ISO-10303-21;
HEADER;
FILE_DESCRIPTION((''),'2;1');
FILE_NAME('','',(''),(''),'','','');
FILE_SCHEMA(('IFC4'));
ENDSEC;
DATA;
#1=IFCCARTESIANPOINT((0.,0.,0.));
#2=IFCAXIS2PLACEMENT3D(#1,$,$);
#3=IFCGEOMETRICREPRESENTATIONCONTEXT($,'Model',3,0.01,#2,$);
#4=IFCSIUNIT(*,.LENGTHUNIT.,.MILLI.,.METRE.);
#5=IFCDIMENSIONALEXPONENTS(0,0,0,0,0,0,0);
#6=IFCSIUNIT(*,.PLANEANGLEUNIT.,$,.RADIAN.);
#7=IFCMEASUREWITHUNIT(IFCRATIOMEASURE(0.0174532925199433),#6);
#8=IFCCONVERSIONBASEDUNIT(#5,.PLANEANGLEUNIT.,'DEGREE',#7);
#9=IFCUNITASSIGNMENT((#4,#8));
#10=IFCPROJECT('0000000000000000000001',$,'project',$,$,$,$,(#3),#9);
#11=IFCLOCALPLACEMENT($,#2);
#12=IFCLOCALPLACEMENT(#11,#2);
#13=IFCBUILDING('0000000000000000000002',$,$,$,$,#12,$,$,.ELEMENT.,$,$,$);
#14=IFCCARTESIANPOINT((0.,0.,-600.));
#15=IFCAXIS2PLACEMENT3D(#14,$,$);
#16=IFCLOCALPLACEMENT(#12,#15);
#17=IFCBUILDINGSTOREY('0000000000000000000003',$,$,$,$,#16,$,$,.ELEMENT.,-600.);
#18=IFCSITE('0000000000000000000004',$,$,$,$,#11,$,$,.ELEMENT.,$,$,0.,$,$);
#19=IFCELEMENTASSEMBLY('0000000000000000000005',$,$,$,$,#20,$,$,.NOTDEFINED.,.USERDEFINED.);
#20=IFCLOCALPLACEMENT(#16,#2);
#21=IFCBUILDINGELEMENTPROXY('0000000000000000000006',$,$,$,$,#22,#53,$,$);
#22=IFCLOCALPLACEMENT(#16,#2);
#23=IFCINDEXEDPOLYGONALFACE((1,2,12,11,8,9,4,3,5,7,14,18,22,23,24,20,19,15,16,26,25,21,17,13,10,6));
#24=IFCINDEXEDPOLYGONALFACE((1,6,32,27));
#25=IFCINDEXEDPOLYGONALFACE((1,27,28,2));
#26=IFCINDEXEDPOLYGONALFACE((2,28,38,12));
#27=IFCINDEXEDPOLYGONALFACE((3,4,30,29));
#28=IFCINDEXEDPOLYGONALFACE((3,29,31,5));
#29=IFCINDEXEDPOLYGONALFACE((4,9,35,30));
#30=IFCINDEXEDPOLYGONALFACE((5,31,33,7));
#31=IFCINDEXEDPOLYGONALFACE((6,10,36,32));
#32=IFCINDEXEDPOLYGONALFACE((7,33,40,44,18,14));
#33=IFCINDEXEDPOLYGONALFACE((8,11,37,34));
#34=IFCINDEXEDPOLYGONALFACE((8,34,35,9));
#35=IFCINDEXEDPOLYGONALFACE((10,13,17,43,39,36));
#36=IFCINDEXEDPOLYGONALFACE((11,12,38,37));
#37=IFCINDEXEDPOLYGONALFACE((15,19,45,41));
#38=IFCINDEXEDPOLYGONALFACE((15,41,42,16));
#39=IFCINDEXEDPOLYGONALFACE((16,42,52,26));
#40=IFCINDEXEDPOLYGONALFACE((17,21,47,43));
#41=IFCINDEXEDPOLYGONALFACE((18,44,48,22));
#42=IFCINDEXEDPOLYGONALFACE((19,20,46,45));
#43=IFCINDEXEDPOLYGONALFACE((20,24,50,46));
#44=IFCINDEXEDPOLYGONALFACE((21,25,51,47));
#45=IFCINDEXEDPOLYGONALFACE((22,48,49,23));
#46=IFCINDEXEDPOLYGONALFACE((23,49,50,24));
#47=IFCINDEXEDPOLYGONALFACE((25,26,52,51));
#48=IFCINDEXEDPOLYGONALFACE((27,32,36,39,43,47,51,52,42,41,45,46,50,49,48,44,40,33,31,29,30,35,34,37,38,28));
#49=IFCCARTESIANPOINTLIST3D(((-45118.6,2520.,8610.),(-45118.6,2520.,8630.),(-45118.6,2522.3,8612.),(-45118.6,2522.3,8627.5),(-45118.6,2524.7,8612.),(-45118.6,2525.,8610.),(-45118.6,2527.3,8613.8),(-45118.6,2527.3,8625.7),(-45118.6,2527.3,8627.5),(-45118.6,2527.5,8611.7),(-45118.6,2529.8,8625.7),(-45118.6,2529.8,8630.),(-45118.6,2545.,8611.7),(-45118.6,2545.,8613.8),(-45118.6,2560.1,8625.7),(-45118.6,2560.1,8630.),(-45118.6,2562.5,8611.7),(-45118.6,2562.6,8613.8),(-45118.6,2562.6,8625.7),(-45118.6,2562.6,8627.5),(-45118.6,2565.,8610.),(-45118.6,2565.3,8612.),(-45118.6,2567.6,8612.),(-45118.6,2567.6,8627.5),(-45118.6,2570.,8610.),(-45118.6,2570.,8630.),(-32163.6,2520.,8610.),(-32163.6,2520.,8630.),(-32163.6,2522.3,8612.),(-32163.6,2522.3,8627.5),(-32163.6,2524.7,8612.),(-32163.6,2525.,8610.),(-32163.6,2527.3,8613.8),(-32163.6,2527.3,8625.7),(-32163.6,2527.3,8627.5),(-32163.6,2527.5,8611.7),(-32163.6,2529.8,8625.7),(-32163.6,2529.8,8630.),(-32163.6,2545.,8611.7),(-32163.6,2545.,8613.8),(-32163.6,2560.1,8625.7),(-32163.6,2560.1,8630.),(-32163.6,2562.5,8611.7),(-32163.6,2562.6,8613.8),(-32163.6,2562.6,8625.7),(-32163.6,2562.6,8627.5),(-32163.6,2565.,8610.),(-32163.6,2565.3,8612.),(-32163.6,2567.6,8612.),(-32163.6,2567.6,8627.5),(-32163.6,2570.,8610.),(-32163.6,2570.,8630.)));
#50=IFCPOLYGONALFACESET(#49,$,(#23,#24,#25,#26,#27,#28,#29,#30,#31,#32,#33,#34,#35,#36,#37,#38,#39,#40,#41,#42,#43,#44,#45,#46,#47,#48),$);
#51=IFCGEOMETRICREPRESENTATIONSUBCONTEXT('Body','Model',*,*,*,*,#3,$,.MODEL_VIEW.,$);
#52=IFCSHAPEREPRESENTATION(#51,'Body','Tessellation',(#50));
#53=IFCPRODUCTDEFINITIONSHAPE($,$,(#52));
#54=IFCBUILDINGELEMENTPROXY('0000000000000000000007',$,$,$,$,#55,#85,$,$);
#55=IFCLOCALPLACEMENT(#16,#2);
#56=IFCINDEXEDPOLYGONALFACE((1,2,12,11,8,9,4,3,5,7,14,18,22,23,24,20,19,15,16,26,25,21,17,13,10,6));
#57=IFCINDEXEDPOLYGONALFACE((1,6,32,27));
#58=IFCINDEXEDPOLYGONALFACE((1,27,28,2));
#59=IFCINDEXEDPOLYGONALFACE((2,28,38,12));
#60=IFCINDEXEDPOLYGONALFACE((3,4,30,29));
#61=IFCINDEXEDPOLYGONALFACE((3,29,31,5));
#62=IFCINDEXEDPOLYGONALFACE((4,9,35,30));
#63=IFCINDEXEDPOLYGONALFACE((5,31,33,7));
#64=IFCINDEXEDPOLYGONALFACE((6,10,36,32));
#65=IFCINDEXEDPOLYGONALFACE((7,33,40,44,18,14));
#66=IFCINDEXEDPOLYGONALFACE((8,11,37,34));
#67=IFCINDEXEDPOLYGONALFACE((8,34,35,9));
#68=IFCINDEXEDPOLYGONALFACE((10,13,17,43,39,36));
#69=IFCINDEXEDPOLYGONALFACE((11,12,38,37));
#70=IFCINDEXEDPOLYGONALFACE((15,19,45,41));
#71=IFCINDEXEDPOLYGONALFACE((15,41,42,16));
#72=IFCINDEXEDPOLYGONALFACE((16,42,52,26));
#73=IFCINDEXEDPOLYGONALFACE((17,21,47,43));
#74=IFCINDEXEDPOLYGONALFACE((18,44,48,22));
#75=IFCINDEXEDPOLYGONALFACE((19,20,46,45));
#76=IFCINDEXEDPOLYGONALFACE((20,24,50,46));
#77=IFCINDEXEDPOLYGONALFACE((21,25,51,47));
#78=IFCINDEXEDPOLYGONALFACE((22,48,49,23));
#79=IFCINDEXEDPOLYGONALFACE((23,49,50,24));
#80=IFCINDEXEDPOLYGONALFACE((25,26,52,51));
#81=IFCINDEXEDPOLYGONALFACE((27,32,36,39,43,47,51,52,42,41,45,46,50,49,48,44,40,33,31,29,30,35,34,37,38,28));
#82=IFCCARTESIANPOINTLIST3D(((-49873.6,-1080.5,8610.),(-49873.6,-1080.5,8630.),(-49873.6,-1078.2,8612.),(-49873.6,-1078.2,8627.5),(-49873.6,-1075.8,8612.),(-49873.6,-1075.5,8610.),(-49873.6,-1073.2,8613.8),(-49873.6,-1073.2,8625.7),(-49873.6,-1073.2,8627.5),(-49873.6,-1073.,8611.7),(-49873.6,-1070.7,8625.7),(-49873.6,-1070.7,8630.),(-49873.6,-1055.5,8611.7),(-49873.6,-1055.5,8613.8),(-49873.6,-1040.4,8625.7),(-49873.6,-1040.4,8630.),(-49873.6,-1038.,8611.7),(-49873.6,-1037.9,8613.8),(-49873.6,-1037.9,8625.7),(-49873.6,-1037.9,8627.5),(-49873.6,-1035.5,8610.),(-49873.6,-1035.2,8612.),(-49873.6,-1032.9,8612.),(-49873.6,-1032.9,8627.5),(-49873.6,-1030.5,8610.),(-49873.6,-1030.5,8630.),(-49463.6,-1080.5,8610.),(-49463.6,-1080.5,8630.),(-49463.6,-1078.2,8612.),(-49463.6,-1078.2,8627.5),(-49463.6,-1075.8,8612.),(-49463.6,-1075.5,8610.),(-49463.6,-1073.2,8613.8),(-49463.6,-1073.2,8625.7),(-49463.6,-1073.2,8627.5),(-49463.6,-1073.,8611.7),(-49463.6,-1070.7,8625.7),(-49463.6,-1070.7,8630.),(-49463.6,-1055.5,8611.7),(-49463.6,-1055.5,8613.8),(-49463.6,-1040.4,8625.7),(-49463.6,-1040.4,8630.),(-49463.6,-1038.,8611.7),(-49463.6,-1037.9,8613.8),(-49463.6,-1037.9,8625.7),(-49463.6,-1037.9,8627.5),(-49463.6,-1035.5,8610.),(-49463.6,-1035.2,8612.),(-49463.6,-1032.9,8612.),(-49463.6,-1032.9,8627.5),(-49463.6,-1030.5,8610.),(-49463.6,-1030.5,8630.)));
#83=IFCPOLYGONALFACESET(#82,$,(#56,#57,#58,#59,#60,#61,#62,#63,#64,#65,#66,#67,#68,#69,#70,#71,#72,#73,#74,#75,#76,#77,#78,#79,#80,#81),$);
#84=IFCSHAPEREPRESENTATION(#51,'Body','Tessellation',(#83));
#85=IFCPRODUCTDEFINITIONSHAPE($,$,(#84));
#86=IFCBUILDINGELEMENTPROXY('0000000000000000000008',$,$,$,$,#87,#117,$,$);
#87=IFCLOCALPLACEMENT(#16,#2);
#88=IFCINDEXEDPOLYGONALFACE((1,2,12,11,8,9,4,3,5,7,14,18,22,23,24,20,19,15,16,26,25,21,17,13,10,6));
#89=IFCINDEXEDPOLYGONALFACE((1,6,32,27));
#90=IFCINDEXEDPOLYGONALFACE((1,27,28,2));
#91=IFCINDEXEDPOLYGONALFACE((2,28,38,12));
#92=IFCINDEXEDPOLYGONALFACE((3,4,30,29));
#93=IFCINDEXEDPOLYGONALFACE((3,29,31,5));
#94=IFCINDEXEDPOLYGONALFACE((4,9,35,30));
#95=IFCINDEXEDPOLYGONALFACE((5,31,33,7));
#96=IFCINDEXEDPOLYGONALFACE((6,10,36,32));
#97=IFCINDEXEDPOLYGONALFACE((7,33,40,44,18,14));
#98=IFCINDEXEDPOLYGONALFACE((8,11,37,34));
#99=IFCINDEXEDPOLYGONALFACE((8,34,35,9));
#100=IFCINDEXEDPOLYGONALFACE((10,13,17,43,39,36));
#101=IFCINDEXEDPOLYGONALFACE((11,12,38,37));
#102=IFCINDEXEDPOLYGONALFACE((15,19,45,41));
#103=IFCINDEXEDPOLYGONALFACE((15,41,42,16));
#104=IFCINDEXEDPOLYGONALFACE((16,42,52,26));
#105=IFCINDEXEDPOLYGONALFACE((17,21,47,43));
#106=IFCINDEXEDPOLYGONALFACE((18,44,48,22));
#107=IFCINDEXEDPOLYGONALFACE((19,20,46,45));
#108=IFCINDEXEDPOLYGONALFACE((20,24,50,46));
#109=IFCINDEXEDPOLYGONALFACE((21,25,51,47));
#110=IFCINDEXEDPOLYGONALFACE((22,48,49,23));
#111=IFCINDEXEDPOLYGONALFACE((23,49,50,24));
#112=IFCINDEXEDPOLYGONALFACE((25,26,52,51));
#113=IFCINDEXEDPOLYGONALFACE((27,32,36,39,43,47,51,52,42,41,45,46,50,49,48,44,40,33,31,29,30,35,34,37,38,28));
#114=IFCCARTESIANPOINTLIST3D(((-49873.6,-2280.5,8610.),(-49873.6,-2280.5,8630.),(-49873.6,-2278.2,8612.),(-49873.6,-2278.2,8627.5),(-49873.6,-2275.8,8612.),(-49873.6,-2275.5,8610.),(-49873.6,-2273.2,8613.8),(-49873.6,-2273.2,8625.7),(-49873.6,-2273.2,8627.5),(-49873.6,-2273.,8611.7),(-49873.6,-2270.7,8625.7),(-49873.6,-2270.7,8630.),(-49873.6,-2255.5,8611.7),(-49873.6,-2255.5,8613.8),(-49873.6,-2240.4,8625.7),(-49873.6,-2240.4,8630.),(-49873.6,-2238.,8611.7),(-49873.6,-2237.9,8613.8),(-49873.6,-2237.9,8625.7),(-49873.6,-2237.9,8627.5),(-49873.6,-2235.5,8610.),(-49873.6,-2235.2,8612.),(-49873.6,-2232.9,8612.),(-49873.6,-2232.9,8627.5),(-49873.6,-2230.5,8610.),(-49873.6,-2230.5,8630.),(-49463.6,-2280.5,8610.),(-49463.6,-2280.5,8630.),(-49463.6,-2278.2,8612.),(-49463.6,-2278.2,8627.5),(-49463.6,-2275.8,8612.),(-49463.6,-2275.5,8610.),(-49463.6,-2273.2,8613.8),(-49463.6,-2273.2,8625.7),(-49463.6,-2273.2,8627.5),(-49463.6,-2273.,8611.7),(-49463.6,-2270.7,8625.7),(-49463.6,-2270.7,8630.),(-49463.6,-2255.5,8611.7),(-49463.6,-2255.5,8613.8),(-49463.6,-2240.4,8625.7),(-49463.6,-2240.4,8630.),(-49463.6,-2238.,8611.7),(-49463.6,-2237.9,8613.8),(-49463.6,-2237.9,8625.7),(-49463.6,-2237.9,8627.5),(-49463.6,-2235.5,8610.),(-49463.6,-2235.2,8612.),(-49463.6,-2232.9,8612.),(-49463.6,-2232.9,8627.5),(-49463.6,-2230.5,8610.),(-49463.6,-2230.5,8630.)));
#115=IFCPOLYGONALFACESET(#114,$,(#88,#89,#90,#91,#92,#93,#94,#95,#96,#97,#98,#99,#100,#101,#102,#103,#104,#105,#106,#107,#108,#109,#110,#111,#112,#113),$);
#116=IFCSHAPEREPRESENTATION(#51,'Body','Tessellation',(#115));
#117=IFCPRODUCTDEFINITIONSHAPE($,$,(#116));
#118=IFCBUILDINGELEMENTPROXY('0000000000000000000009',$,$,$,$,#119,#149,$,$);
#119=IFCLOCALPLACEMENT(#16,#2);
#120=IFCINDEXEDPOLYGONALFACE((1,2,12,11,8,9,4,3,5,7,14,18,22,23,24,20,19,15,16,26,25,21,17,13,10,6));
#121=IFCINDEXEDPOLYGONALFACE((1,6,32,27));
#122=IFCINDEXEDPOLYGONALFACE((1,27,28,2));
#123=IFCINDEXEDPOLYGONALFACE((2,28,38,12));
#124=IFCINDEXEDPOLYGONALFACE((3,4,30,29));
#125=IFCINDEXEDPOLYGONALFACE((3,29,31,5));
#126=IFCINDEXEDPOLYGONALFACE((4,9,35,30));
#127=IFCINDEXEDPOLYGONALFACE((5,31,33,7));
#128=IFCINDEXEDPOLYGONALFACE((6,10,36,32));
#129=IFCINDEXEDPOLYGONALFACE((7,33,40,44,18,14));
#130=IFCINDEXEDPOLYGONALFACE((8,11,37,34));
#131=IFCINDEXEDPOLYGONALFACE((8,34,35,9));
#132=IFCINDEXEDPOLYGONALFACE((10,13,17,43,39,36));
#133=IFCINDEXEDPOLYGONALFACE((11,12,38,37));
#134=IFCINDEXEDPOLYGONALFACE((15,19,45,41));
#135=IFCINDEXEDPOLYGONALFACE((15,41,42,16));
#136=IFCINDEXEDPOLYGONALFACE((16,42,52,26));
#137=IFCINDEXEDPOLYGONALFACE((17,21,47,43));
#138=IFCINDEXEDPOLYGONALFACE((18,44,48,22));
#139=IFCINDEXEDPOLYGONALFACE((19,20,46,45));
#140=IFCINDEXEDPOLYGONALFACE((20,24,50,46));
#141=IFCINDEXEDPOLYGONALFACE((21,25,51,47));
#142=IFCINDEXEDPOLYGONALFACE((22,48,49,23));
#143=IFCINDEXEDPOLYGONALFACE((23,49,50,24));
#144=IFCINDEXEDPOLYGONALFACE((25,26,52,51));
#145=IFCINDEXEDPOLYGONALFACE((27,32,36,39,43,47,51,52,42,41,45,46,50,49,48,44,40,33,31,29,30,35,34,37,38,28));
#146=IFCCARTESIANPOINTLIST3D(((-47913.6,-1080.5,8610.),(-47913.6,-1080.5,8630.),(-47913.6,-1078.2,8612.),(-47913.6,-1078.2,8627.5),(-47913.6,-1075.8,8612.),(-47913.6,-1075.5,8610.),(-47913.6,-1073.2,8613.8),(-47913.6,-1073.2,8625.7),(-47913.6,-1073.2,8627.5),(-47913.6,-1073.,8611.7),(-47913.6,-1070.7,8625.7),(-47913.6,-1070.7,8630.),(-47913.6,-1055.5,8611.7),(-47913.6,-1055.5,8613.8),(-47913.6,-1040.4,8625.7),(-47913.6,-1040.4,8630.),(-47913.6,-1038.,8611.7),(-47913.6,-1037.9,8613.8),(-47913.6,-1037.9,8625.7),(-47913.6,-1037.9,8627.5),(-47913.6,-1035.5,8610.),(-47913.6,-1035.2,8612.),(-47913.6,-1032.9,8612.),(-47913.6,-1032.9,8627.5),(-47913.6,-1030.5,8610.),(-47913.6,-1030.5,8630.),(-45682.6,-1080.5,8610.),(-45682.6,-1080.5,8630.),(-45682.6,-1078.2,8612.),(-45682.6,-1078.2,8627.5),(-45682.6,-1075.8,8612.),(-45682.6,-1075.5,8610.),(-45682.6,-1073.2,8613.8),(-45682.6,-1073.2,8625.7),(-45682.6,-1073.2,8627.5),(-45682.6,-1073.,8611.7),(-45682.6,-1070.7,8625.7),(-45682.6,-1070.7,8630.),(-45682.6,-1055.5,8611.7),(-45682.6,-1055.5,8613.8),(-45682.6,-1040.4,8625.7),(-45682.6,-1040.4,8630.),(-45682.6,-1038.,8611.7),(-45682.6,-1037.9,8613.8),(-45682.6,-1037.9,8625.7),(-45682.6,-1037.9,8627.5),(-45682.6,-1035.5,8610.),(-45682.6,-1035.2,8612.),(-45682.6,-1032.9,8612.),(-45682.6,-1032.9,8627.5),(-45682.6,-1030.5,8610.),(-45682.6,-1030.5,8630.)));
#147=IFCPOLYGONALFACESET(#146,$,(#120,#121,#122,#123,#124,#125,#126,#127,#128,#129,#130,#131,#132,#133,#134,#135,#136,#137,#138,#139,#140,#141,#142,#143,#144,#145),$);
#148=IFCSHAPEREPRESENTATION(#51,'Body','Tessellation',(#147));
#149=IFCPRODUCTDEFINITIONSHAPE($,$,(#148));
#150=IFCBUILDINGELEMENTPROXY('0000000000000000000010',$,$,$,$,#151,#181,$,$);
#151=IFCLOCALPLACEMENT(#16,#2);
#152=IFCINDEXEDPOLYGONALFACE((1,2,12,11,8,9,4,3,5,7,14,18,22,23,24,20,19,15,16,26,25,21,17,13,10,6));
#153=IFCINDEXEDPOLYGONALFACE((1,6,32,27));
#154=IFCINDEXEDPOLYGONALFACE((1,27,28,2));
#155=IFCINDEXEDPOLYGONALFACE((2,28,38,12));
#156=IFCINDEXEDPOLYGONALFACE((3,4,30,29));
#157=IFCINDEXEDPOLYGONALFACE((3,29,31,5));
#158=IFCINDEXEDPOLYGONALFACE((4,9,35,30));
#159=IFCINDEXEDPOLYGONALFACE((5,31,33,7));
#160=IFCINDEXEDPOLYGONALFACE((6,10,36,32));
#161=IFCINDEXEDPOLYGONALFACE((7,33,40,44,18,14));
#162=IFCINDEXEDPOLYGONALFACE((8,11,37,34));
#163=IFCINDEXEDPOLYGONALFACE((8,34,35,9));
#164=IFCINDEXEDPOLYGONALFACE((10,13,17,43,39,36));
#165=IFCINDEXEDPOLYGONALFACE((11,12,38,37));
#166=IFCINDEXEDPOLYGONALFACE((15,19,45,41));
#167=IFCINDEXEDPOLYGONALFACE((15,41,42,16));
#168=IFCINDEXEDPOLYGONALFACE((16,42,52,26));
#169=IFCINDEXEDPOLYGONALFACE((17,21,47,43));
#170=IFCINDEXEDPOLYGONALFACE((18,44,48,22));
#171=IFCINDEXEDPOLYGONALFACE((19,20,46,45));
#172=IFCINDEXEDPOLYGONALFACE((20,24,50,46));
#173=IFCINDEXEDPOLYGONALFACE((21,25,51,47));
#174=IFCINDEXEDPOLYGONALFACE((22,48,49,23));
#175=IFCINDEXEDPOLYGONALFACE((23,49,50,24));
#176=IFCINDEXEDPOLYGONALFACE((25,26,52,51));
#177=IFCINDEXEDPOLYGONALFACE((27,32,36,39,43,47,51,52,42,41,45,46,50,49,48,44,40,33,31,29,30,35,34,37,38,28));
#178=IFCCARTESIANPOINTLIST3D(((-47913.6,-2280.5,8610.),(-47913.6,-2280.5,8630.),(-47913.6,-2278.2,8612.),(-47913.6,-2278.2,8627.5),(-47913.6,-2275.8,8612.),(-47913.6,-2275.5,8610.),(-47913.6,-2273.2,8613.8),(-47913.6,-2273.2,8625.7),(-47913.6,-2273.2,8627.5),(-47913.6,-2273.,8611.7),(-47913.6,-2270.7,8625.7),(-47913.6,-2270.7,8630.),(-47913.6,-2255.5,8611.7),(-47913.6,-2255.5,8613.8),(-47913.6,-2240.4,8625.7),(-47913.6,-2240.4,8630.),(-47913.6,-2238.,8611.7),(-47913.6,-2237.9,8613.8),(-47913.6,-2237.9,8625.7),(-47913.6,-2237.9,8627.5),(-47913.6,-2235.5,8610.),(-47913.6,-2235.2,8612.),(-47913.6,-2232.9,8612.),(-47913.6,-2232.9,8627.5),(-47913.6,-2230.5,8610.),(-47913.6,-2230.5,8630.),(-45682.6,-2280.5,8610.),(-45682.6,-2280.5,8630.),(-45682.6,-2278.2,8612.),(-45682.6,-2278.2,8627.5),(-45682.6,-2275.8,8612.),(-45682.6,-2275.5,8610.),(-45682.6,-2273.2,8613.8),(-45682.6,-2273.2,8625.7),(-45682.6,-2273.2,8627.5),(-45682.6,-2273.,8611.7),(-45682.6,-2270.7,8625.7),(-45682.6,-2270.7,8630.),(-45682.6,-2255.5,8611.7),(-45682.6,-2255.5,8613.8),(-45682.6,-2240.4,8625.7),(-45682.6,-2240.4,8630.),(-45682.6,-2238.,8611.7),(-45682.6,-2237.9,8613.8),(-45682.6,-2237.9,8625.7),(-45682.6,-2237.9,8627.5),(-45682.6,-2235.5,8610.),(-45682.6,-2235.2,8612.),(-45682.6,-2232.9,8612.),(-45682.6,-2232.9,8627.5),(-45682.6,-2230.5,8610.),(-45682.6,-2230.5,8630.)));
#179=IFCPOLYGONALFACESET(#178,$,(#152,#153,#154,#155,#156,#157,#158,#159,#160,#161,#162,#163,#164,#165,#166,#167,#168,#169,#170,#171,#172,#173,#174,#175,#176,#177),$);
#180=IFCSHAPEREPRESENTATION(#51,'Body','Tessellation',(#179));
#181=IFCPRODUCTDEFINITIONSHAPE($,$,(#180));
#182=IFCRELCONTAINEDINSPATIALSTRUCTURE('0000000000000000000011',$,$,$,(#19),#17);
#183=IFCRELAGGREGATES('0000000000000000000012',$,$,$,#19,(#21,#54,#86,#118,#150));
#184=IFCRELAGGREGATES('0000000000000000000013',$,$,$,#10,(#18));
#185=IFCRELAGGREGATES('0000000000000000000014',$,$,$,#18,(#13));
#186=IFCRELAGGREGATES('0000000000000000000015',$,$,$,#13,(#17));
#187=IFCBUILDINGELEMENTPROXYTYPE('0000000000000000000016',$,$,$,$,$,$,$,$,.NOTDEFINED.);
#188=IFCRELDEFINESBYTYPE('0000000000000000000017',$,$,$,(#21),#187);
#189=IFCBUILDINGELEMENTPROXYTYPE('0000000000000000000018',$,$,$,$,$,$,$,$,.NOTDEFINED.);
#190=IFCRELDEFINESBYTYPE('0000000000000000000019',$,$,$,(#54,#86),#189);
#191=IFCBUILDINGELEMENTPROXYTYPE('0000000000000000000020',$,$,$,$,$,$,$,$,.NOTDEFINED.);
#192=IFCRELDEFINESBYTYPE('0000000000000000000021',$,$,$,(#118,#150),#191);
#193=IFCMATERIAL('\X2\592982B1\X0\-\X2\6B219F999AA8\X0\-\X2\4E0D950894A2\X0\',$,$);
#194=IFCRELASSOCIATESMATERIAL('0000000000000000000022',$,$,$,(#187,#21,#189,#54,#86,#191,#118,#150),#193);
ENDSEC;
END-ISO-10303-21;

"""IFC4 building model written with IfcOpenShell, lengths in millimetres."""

from ifc_helpers import new_model, entity, si_unit, converted_unit, frame, origin, place, context, subcontext, project, spatial, polyline, outline, extrude, source, transform, mapped, material, type_object, type_shapes, element, aggregate, save


model = new_model("IFC4")

# Units and contexts
model_context = context("Model", 3, precision=0.01, world=origin())
body_context = subcontext(model_context, "Body", "Model", "MODEL_VIEW")
ifc_project = project(units=[si_unit("LENGTHUNIT", "METRE", prefix="MILLI"), converted_unit("PLANEANGLEUNIT", "DEGREE", entity("IfcRatioMeasure", 0.0174532925199433), si_unit("PLANEANGLEUNIT", "RADIAN"), dimensions=[0, 0, 0, 0, 0, 0, 0])], contexts=[model_context])

# Site, building, storey
site_placement = place(None, origin())
site = spatial("IfcSite", under=ifc_project, at=site_placement, CompositionType="ELEMENT", RefElevation=0.0)
building_placement = place(site_placement, origin())
building = spatial("IfcBuilding", under=site, at=building_placement, CompositionType="ELEMENT")
storey_placement = place(building_placement, frame((0.0, 0.0, -600.0)))
storey = spatial("IfcBuildingStorey", under=building, at=storey_placement, CompositionType="ELEMENT", Elevation=-600.0)

# Element assembly, building element proxies
assembly_1_placement = place(storey_placement, origin())
assembly_1 = element("IfcElementAssembly", 1, at=assembly_1_placement, inside=storey, AssemblyPlace="NOTDEFINED", PredefinedType="USERDEFINED")
ifc_material_1 = material(Name="天花-次龙骨-不锈钢")
building_element_proxy_type_1 = type_object("IfcBuildingElementProxyType", PredefinedType="NOTDEFINED", material=ifc_material_1)
shared_shape_1 = source(origin(), body_context, "Body", "SweptSolid", [
    extrude(outline(polyline([(-25.0, -9.1), (-20.0, -9.1), (-17.5, -7.4), (0.0, -7.4), (17.5, -7.4), (20.0, -9.1), (25.0, -9.1), (25.0, 10.9), (15.1, 10.9), (15.1, 6.6), (17.6, 6.6), (17.6, 8.4), (22.6, 8.4), (22.6, -7.1), (20.3, -7.1), (17.6, -5.3), (0.0, -5.3), (-17.6, -5.3), (-20.3, -7.1), (-22.6, -7.1), (-22.6, 8.4), (-17.6, 8.4), (-17.6, 6.6), (-15.1, 6.6), (-15.1, 10.9), (-25.0, 10.9), (-25.0, -9.1)])), frame((0.0, 0.0, -0.9), z_axis=(1.0, 0.0, 0.0), x_axis=(0.0, 1.0, 0.0)), (0.0, 0.0, 1.0), 12955.0),
])
type_shapes(building_element_proxy_type_1, [shared_shape_1])
proxy_1_placement = place(assembly_1_placement, frame((-45118.6, 2545.0, 8620.0)))
proxy_1 = element("IfcBuildingElementProxy", 2, at=proxy_1_placement, type_object=building_element_proxy_type_1, material=ifc_material_1, context=body_context, shape_type="MappedRepresentation", body=[
    mapped(shared_shape_1, transform((0.0, 0.0, 0.0), scale=1.0)),
])
building_element_proxy_type_2 = type_object("IfcBuildingElementProxyType", PredefinedType="NOTDEFINED", material=ifc_material_1)
shared_shape_2 = source(origin(), body_context, "Body", "SweptSolid", [
    extrude(outline(polyline([(-25.0, -9.1), (-20.0, -9.1), (-17.5, -7.4), (0.0, -7.4), (17.5, -7.4), (20.0, -9.1), (25.0, -9.1), (25.0, 10.9), (15.1, 10.9), (15.1, 6.6), (17.6, 6.6), (17.6, 8.4), (22.6, 8.4), (22.6, -7.1), (20.3, -7.1), (17.6, -5.3), (0.0, -5.3), (-17.6, -5.3), (-20.3, -7.1), (-22.6, -7.1), (-22.6, 8.4), (-17.6, 8.4), (-17.6, 6.6), (-15.1, 6.6), (-15.1, 10.9), (-25.0, 10.9), (-25.0, -9.1)])), frame((0.0, 0.0, -0.9), z_axis=(1.0, 0.0, 0.0), x_axis=(0.0, 1.0, 0.0)), (0.0, 0.0, 1.0), 410.0),
])
type_shapes(building_element_proxy_type_2, [shared_shape_2])
proxy_2_placement = place(assembly_1_placement, frame((-49873.6, -1055.5, 8620.0)))
proxy_2 = element("IfcBuildingElementProxy", 3, at=proxy_2_placement, type_object=building_element_proxy_type_2, material=ifc_material_1, context=body_context, shape_type="MappedRepresentation", body=[
    mapped(shared_shape_2, transform((0.0, 0.0, 0.0), scale=1.0)),
])
proxy_3_placement = place(assembly_1_placement, frame((-49873.6, -2255.5, 8620.0)))
proxy_3 = element("IfcBuildingElementProxy", 4, at=proxy_3_placement, type_object=building_element_proxy_type_2, material=ifc_material_1, context=body_context, shape_type="MappedRepresentation", body=[
    mapped(shared_shape_2, transform((0.0, 0.0, 0.0), scale=1.0)),
])
building_element_proxy_type_3 = type_object("IfcBuildingElementProxyType", PredefinedType="NOTDEFINED", material=ifc_material_1)
shared_shape_3 = source(origin(), body_context, "Body", "SweptSolid", [
    extrude(outline(polyline([(-25.0, -9.1), (-20.0, -9.1), (-17.5, -7.4), (0.0, -7.4), (17.5, -7.4), (20.0, -9.1), (25.0, -9.1), (25.0, 10.9), (15.1, 10.9), (15.1, 6.6), (17.6, 6.6), (17.6, 8.4), (22.6, 8.4), (22.6, -7.1), (20.3, -7.1), (17.6, -5.3), (0.0, -5.3), (-17.6, -5.3), (-20.3, -7.1), (-22.6, -7.1), (-22.6, 8.4), (-17.6, 8.4), (-17.6, 6.6), (-15.1, 6.6), (-15.1, 10.9), (-25.0, 10.9), (-25.0, -9.1)])), frame((0.0, 0.0, -0.9), z_axis=(1.0, 0.0, 0.0), x_axis=(0.0, 1.0, 0.0)), (0.0, 0.0, 1.0), 2231.0),
])
type_shapes(building_element_proxy_type_3, [shared_shape_3])
proxy_4_placement = place(assembly_1_placement, frame((-47913.6, -1055.5, 8620.0)))
proxy_4 = element("IfcBuildingElementProxy", 5, at=proxy_4_placement, type_object=building_element_proxy_type_3, material=ifc_material_1, context=body_context, shape_type="MappedRepresentation", body=[
    mapped(shared_shape_3, transform((0.0, 0.0, 0.0), scale=1.0)),
])
proxy_5_placement = place(assembly_1_placement, frame((-47913.6, -2255.5, 8620.0)))
proxy_5 = element("IfcBuildingElementProxy", 6, at=proxy_5_placement, type_object=building_element_proxy_type_3, material=ifc_material_1, context=body_context, shape_type="MappedRepresentation", body=[
    mapped(shared_shape_3, transform((0.0, 0.0, 0.0), scale=1.0)),
])
aggregate(assembly_1, [proxy_1, proxy_2, proxy_3, proxy_4, proxy_5])

save(model, "model.ifc")
